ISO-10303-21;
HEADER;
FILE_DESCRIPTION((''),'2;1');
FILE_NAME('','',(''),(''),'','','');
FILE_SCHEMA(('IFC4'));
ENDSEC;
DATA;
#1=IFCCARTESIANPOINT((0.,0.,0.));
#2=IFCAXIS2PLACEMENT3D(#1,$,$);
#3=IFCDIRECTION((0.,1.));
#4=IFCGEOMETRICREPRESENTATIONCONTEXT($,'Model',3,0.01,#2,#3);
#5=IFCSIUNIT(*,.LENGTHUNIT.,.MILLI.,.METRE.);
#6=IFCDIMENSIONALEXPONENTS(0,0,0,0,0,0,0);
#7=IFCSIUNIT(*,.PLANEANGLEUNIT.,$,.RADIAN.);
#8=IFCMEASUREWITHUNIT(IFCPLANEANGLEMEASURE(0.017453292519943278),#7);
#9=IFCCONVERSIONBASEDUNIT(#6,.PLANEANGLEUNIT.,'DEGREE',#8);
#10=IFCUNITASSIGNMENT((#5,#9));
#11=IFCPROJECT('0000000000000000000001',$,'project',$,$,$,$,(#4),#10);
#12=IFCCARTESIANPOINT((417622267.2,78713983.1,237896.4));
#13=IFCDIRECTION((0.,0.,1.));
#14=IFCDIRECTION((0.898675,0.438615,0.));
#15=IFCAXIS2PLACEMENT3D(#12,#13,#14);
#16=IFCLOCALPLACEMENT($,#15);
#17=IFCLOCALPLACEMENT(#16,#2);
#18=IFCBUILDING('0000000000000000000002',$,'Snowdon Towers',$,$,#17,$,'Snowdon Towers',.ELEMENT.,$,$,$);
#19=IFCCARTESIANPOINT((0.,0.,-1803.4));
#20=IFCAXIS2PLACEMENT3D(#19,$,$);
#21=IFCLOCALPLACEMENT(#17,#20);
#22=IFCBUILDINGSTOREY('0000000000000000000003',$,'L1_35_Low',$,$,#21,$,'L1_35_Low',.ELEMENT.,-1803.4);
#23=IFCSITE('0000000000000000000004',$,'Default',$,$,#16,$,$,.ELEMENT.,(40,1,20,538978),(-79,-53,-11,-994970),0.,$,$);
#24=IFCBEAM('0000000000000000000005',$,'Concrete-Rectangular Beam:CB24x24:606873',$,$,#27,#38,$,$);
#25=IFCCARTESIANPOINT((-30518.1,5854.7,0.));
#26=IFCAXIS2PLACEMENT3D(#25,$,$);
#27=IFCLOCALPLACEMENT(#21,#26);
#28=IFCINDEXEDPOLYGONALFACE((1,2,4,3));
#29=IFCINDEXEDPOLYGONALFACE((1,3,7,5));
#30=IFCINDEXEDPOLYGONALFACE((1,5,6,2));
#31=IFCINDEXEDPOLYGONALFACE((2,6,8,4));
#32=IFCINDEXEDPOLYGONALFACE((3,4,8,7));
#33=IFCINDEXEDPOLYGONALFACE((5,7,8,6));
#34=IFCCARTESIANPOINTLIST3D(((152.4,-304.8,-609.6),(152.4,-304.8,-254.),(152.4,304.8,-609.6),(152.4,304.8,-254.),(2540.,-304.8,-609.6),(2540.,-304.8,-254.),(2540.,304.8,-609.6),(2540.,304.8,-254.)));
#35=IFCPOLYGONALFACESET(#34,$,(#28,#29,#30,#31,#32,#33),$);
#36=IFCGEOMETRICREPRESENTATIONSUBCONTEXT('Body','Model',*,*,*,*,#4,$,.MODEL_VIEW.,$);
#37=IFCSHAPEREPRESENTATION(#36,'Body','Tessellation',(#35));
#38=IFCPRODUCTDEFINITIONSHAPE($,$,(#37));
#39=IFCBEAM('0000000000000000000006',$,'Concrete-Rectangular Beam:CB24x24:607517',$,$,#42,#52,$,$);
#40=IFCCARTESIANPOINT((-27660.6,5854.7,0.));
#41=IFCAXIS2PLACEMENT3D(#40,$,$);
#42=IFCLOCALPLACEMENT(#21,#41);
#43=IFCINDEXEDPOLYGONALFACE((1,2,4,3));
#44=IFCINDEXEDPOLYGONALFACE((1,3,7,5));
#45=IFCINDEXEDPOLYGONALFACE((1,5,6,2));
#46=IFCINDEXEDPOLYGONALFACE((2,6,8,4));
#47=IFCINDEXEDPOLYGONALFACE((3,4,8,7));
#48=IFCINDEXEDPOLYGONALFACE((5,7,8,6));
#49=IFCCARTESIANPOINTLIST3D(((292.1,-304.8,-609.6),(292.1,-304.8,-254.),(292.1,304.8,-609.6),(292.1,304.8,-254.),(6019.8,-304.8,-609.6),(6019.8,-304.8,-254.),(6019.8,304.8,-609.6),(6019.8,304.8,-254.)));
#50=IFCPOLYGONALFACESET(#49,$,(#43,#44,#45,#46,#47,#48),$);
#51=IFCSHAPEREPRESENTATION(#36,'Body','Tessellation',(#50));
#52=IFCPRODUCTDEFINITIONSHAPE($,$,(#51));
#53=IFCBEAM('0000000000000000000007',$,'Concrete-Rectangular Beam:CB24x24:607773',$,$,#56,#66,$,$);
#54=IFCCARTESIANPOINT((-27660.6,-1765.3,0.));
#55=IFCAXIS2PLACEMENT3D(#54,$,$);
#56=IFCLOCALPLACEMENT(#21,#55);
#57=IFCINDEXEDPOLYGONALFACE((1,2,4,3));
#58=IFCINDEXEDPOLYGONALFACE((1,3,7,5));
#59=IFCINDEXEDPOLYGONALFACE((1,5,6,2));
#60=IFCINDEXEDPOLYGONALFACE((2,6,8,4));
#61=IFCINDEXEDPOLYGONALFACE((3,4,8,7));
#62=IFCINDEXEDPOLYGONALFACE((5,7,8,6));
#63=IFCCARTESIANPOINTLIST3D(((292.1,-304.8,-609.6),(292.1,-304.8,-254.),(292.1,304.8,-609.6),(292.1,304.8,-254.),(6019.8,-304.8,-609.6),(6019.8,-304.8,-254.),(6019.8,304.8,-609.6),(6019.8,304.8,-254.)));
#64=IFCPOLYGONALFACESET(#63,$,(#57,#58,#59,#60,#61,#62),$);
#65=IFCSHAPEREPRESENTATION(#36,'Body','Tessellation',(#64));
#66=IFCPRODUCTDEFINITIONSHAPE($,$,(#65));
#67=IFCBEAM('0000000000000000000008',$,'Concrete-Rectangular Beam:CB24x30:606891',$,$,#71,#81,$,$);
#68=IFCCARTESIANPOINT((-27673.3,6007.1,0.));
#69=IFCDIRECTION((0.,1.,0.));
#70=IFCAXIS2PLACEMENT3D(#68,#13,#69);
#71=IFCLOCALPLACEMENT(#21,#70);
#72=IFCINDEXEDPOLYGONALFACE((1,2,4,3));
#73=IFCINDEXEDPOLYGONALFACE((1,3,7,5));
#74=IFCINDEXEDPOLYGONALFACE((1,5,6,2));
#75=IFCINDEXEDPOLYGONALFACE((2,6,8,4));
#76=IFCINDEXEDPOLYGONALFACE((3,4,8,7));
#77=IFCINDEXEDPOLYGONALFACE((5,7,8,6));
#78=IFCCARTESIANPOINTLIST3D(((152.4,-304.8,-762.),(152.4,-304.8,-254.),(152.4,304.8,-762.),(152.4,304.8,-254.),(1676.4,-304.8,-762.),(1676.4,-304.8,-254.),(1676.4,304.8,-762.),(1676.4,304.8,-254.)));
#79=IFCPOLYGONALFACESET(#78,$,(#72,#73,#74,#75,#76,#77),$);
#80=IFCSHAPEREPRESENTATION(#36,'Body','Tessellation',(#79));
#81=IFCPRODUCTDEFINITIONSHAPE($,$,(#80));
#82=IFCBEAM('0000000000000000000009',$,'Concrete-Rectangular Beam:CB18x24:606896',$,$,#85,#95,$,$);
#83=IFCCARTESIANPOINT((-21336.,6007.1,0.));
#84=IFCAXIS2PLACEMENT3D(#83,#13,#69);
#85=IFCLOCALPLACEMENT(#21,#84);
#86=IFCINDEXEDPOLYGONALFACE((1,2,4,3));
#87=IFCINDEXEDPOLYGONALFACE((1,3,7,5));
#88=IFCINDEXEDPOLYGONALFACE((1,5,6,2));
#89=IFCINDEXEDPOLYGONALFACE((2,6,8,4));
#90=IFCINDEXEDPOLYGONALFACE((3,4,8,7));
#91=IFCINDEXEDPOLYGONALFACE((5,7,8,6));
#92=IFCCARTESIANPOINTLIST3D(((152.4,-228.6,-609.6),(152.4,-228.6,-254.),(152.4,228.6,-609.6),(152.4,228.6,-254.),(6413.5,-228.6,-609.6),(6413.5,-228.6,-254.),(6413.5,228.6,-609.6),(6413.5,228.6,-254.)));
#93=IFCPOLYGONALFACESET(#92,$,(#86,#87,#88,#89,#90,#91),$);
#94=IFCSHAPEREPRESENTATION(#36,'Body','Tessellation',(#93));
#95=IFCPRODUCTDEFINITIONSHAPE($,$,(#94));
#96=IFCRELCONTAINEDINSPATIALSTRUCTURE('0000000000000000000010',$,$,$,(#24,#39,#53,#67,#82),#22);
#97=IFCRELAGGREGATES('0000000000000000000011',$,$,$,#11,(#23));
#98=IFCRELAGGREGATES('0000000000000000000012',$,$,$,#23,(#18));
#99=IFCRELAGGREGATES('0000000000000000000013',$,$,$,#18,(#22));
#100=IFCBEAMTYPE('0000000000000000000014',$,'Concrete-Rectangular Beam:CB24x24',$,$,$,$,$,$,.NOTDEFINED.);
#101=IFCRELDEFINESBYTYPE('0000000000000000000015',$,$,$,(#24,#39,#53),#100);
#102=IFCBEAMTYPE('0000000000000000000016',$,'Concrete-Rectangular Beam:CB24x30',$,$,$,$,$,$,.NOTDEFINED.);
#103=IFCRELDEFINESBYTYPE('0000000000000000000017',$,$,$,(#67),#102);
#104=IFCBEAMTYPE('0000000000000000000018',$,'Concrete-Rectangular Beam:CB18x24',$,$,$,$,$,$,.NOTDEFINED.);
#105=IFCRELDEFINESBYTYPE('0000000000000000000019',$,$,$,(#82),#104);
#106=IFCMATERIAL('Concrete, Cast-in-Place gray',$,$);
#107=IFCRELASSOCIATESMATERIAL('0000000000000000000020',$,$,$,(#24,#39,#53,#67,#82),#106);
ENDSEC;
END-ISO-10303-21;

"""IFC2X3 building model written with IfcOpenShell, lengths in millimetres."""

from ifc_helpers import new_model, entity, si_unit, converted_unit, direction, frame, frame_2d, origin, place, context, subcontext, project, spatial, rectangle, extrude, material, type_object, element, save


model = new_model("IFC2X3")

# Units and contexts
model_context = context("Model", 3, precision=0.01, world=origin(), true_north=direction((0.0, 1.0)))
body_context = subcontext(model_context, "Body", "Model", "MODEL_VIEW")
ifc_project = project(units=[si_unit("LENGTHUNIT", "METRE", prefix="MILLI"), converted_unit("PLANEANGLEUNIT", "DEGREE", entity("IfcPlaneAngleMeasure", 0.017453292519943278), si_unit("PLANEANGLEUNIT", "RADIAN"), dimensions=[0, 0, 0, 0, 0, 0, 0])], contexts=[model_context])

# Site, building, storey
site_placement = place(None, frame((417622267.2, 78713983.1, 237896.4), z_axis=(0.0, 0.0, 1.0), x_axis=(0.898675, 0.438615, 0.0)))
site = spatial("IfcSite", under=ifc_project, at=site_placement, Name="Default", CompositionType="ELEMENT", RefLatitude=(40, 1, 20, 538978), RefLongitude=(-79, -53, -11, -994970), RefElevation=0.0)
building_placement = place(site_placement, origin())
building = spatial("IfcBuilding", under=site, at=building_placement, Name="Snowdon Towers", LongName="Snowdon Towers", CompositionType="ELEMENT")
storey_placement = place(building_placement, frame((0.0, 0.0, -1803.4)))
storey = spatial("IfcBuildingStorey", under=building, at=storey_placement, Name="L1_35_Low", LongName="L1_35_Low", CompositionType="ELEMENT", Elevation=-1803.4)

# Beams
ifc_material_1 = material(Name="Concrete, Cast-in-Place gray")
beam_type_1 = type_object("IfcBeamType", Name="Concrete-Rectangular Beam:CB24x24", PredefinedType="NOTDEFINED")
beam_1_placement = place(storey_placement, frame((-30518.1, 5854.7, 0.0)))
element("IfcBeam", 1, at=beam_1_placement, inside=storey, type_object=beam_type_1, material=ifc_material_1, Name="Concrete-Rectangular Beam:CB24x24:606873", context=body_context, shape_type="SweptSolid", body=[
    extrude(rectangle(XDim=355.6, YDim=609.6, at=frame_2d((0.0, 0.0), x_axis=(1.0, 0.0))), frame((152.4, 0.0, -431.8), z_axis=(1.0, 0.0, 0.0), x_axis=(0.0, 0.0, -1.0)), (0.0, 0.0, 1.0), 2387.6),
])
beam_2_placement = place(storey_placement, frame((-27660.6, 5854.7, 0.0)))
element("IfcBeam", 2, at=beam_2_placement, inside=storey, type_object=beam_type_1, material=ifc_material_1, Name="Concrete-Rectangular Beam:CB24x24:607517", context=body_context, shape_type="SweptSolid", body=[
    extrude(rectangle(XDim=355.6, YDim=609.6, at=frame_2d((0.0, 0.0), x_axis=(1.0, 0.0))), frame((292.1, 0.0, -431.8), z_axis=(1.0, 0.0, 0.0), x_axis=(0.0, 0.0, -1.0)), (0.0, 0.0, 1.0), 5727.7),
])
beam_3_placement = place(storey_placement, frame((-27660.6, -1765.3, 0.0)))
element("IfcBeam", 3, at=beam_3_placement, inside=storey, type_object=beam_type_1, material=ifc_material_1, Name="Concrete-Rectangular Beam:CB24x24:607773", context=body_context, shape_type="SweptSolid", body=[
    extrude(rectangle(XDim=355.6, YDim=609.6, at=frame_2d((0.0, 0.0), x_axis=(1.0, 0.0))), frame((292.1, 0.0, -431.8), z_axis=(1.0, 0.0, 0.0), x_axis=(0.0, 0.0, -1.0)), (0.0, 0.0, 1.0), 5727.7),
])
beam_type_2 = type_object("IfcBeamType", Name="Concrete-Rectangular Beam:CB24x30", PredefinedType="NOTDEFINED")
beam_4_placement = place(storey_placement, frame((-27673.3, 6007.1, 0.0), z_axis=(0.0, 0.0, 1.0), x_axis=(0.0, 1.0, 0.0)))
element("IfcBeam", 4, at=beam_4_placement, inside=storey, type_object=beam_type_2, material=ifc_material_1, Name="Concrete-Rectangular Beam:CB24x30:606891", context=body_context, shape_type="SweptSolid", body=[
    extrude(rectangle(XDim=508.0, YDim=609.6, at=frame_2d((0.0, 0.0), x_axis=(1.0, 0.0))), frame((152.4, 0.0, -508.0), z_axis=(1.0, 0.0, 0.0), x_axis=(0.0, 0.0, -1.0)), (0.0, 0.0, 1.0), 1524.0),
])
beam_type_3 = type_object("IfcBeamType", Name="Concrete-Rectangular Beam:CB18x24", PredefinedType="NOTDEFINED")
beam_5_placement = place(storey_placement, frame((-21336.0, 6007.1, 0.0), z_axis=(0.0, 0.0, 1.0), x_axis=(0.0, 1.0, 0.0)))
element("IfcBeam", 5, at=beam_5_placement, inside=storey, type_object=beam_type_3, material=ifc_material_1, Name="Concrete-Rectangular Beam:CB18x24:606896", context=body_context, shape_type="SweptSolid", body=[
    extrude(rectangle(XDim=355.6, YDim=457.2, at=frame_2d((0.0, 0.0), x_axis=(1.0, 0.0))), frame((152.4, 0.0, -431.8), z_axis=(1.0, 0.0, 0.0), x_axis=(0.0, 0.0, -1.0)), (0.0, 0.0, 1.0), 6261.1),
])

save(model, "model.ifc")
